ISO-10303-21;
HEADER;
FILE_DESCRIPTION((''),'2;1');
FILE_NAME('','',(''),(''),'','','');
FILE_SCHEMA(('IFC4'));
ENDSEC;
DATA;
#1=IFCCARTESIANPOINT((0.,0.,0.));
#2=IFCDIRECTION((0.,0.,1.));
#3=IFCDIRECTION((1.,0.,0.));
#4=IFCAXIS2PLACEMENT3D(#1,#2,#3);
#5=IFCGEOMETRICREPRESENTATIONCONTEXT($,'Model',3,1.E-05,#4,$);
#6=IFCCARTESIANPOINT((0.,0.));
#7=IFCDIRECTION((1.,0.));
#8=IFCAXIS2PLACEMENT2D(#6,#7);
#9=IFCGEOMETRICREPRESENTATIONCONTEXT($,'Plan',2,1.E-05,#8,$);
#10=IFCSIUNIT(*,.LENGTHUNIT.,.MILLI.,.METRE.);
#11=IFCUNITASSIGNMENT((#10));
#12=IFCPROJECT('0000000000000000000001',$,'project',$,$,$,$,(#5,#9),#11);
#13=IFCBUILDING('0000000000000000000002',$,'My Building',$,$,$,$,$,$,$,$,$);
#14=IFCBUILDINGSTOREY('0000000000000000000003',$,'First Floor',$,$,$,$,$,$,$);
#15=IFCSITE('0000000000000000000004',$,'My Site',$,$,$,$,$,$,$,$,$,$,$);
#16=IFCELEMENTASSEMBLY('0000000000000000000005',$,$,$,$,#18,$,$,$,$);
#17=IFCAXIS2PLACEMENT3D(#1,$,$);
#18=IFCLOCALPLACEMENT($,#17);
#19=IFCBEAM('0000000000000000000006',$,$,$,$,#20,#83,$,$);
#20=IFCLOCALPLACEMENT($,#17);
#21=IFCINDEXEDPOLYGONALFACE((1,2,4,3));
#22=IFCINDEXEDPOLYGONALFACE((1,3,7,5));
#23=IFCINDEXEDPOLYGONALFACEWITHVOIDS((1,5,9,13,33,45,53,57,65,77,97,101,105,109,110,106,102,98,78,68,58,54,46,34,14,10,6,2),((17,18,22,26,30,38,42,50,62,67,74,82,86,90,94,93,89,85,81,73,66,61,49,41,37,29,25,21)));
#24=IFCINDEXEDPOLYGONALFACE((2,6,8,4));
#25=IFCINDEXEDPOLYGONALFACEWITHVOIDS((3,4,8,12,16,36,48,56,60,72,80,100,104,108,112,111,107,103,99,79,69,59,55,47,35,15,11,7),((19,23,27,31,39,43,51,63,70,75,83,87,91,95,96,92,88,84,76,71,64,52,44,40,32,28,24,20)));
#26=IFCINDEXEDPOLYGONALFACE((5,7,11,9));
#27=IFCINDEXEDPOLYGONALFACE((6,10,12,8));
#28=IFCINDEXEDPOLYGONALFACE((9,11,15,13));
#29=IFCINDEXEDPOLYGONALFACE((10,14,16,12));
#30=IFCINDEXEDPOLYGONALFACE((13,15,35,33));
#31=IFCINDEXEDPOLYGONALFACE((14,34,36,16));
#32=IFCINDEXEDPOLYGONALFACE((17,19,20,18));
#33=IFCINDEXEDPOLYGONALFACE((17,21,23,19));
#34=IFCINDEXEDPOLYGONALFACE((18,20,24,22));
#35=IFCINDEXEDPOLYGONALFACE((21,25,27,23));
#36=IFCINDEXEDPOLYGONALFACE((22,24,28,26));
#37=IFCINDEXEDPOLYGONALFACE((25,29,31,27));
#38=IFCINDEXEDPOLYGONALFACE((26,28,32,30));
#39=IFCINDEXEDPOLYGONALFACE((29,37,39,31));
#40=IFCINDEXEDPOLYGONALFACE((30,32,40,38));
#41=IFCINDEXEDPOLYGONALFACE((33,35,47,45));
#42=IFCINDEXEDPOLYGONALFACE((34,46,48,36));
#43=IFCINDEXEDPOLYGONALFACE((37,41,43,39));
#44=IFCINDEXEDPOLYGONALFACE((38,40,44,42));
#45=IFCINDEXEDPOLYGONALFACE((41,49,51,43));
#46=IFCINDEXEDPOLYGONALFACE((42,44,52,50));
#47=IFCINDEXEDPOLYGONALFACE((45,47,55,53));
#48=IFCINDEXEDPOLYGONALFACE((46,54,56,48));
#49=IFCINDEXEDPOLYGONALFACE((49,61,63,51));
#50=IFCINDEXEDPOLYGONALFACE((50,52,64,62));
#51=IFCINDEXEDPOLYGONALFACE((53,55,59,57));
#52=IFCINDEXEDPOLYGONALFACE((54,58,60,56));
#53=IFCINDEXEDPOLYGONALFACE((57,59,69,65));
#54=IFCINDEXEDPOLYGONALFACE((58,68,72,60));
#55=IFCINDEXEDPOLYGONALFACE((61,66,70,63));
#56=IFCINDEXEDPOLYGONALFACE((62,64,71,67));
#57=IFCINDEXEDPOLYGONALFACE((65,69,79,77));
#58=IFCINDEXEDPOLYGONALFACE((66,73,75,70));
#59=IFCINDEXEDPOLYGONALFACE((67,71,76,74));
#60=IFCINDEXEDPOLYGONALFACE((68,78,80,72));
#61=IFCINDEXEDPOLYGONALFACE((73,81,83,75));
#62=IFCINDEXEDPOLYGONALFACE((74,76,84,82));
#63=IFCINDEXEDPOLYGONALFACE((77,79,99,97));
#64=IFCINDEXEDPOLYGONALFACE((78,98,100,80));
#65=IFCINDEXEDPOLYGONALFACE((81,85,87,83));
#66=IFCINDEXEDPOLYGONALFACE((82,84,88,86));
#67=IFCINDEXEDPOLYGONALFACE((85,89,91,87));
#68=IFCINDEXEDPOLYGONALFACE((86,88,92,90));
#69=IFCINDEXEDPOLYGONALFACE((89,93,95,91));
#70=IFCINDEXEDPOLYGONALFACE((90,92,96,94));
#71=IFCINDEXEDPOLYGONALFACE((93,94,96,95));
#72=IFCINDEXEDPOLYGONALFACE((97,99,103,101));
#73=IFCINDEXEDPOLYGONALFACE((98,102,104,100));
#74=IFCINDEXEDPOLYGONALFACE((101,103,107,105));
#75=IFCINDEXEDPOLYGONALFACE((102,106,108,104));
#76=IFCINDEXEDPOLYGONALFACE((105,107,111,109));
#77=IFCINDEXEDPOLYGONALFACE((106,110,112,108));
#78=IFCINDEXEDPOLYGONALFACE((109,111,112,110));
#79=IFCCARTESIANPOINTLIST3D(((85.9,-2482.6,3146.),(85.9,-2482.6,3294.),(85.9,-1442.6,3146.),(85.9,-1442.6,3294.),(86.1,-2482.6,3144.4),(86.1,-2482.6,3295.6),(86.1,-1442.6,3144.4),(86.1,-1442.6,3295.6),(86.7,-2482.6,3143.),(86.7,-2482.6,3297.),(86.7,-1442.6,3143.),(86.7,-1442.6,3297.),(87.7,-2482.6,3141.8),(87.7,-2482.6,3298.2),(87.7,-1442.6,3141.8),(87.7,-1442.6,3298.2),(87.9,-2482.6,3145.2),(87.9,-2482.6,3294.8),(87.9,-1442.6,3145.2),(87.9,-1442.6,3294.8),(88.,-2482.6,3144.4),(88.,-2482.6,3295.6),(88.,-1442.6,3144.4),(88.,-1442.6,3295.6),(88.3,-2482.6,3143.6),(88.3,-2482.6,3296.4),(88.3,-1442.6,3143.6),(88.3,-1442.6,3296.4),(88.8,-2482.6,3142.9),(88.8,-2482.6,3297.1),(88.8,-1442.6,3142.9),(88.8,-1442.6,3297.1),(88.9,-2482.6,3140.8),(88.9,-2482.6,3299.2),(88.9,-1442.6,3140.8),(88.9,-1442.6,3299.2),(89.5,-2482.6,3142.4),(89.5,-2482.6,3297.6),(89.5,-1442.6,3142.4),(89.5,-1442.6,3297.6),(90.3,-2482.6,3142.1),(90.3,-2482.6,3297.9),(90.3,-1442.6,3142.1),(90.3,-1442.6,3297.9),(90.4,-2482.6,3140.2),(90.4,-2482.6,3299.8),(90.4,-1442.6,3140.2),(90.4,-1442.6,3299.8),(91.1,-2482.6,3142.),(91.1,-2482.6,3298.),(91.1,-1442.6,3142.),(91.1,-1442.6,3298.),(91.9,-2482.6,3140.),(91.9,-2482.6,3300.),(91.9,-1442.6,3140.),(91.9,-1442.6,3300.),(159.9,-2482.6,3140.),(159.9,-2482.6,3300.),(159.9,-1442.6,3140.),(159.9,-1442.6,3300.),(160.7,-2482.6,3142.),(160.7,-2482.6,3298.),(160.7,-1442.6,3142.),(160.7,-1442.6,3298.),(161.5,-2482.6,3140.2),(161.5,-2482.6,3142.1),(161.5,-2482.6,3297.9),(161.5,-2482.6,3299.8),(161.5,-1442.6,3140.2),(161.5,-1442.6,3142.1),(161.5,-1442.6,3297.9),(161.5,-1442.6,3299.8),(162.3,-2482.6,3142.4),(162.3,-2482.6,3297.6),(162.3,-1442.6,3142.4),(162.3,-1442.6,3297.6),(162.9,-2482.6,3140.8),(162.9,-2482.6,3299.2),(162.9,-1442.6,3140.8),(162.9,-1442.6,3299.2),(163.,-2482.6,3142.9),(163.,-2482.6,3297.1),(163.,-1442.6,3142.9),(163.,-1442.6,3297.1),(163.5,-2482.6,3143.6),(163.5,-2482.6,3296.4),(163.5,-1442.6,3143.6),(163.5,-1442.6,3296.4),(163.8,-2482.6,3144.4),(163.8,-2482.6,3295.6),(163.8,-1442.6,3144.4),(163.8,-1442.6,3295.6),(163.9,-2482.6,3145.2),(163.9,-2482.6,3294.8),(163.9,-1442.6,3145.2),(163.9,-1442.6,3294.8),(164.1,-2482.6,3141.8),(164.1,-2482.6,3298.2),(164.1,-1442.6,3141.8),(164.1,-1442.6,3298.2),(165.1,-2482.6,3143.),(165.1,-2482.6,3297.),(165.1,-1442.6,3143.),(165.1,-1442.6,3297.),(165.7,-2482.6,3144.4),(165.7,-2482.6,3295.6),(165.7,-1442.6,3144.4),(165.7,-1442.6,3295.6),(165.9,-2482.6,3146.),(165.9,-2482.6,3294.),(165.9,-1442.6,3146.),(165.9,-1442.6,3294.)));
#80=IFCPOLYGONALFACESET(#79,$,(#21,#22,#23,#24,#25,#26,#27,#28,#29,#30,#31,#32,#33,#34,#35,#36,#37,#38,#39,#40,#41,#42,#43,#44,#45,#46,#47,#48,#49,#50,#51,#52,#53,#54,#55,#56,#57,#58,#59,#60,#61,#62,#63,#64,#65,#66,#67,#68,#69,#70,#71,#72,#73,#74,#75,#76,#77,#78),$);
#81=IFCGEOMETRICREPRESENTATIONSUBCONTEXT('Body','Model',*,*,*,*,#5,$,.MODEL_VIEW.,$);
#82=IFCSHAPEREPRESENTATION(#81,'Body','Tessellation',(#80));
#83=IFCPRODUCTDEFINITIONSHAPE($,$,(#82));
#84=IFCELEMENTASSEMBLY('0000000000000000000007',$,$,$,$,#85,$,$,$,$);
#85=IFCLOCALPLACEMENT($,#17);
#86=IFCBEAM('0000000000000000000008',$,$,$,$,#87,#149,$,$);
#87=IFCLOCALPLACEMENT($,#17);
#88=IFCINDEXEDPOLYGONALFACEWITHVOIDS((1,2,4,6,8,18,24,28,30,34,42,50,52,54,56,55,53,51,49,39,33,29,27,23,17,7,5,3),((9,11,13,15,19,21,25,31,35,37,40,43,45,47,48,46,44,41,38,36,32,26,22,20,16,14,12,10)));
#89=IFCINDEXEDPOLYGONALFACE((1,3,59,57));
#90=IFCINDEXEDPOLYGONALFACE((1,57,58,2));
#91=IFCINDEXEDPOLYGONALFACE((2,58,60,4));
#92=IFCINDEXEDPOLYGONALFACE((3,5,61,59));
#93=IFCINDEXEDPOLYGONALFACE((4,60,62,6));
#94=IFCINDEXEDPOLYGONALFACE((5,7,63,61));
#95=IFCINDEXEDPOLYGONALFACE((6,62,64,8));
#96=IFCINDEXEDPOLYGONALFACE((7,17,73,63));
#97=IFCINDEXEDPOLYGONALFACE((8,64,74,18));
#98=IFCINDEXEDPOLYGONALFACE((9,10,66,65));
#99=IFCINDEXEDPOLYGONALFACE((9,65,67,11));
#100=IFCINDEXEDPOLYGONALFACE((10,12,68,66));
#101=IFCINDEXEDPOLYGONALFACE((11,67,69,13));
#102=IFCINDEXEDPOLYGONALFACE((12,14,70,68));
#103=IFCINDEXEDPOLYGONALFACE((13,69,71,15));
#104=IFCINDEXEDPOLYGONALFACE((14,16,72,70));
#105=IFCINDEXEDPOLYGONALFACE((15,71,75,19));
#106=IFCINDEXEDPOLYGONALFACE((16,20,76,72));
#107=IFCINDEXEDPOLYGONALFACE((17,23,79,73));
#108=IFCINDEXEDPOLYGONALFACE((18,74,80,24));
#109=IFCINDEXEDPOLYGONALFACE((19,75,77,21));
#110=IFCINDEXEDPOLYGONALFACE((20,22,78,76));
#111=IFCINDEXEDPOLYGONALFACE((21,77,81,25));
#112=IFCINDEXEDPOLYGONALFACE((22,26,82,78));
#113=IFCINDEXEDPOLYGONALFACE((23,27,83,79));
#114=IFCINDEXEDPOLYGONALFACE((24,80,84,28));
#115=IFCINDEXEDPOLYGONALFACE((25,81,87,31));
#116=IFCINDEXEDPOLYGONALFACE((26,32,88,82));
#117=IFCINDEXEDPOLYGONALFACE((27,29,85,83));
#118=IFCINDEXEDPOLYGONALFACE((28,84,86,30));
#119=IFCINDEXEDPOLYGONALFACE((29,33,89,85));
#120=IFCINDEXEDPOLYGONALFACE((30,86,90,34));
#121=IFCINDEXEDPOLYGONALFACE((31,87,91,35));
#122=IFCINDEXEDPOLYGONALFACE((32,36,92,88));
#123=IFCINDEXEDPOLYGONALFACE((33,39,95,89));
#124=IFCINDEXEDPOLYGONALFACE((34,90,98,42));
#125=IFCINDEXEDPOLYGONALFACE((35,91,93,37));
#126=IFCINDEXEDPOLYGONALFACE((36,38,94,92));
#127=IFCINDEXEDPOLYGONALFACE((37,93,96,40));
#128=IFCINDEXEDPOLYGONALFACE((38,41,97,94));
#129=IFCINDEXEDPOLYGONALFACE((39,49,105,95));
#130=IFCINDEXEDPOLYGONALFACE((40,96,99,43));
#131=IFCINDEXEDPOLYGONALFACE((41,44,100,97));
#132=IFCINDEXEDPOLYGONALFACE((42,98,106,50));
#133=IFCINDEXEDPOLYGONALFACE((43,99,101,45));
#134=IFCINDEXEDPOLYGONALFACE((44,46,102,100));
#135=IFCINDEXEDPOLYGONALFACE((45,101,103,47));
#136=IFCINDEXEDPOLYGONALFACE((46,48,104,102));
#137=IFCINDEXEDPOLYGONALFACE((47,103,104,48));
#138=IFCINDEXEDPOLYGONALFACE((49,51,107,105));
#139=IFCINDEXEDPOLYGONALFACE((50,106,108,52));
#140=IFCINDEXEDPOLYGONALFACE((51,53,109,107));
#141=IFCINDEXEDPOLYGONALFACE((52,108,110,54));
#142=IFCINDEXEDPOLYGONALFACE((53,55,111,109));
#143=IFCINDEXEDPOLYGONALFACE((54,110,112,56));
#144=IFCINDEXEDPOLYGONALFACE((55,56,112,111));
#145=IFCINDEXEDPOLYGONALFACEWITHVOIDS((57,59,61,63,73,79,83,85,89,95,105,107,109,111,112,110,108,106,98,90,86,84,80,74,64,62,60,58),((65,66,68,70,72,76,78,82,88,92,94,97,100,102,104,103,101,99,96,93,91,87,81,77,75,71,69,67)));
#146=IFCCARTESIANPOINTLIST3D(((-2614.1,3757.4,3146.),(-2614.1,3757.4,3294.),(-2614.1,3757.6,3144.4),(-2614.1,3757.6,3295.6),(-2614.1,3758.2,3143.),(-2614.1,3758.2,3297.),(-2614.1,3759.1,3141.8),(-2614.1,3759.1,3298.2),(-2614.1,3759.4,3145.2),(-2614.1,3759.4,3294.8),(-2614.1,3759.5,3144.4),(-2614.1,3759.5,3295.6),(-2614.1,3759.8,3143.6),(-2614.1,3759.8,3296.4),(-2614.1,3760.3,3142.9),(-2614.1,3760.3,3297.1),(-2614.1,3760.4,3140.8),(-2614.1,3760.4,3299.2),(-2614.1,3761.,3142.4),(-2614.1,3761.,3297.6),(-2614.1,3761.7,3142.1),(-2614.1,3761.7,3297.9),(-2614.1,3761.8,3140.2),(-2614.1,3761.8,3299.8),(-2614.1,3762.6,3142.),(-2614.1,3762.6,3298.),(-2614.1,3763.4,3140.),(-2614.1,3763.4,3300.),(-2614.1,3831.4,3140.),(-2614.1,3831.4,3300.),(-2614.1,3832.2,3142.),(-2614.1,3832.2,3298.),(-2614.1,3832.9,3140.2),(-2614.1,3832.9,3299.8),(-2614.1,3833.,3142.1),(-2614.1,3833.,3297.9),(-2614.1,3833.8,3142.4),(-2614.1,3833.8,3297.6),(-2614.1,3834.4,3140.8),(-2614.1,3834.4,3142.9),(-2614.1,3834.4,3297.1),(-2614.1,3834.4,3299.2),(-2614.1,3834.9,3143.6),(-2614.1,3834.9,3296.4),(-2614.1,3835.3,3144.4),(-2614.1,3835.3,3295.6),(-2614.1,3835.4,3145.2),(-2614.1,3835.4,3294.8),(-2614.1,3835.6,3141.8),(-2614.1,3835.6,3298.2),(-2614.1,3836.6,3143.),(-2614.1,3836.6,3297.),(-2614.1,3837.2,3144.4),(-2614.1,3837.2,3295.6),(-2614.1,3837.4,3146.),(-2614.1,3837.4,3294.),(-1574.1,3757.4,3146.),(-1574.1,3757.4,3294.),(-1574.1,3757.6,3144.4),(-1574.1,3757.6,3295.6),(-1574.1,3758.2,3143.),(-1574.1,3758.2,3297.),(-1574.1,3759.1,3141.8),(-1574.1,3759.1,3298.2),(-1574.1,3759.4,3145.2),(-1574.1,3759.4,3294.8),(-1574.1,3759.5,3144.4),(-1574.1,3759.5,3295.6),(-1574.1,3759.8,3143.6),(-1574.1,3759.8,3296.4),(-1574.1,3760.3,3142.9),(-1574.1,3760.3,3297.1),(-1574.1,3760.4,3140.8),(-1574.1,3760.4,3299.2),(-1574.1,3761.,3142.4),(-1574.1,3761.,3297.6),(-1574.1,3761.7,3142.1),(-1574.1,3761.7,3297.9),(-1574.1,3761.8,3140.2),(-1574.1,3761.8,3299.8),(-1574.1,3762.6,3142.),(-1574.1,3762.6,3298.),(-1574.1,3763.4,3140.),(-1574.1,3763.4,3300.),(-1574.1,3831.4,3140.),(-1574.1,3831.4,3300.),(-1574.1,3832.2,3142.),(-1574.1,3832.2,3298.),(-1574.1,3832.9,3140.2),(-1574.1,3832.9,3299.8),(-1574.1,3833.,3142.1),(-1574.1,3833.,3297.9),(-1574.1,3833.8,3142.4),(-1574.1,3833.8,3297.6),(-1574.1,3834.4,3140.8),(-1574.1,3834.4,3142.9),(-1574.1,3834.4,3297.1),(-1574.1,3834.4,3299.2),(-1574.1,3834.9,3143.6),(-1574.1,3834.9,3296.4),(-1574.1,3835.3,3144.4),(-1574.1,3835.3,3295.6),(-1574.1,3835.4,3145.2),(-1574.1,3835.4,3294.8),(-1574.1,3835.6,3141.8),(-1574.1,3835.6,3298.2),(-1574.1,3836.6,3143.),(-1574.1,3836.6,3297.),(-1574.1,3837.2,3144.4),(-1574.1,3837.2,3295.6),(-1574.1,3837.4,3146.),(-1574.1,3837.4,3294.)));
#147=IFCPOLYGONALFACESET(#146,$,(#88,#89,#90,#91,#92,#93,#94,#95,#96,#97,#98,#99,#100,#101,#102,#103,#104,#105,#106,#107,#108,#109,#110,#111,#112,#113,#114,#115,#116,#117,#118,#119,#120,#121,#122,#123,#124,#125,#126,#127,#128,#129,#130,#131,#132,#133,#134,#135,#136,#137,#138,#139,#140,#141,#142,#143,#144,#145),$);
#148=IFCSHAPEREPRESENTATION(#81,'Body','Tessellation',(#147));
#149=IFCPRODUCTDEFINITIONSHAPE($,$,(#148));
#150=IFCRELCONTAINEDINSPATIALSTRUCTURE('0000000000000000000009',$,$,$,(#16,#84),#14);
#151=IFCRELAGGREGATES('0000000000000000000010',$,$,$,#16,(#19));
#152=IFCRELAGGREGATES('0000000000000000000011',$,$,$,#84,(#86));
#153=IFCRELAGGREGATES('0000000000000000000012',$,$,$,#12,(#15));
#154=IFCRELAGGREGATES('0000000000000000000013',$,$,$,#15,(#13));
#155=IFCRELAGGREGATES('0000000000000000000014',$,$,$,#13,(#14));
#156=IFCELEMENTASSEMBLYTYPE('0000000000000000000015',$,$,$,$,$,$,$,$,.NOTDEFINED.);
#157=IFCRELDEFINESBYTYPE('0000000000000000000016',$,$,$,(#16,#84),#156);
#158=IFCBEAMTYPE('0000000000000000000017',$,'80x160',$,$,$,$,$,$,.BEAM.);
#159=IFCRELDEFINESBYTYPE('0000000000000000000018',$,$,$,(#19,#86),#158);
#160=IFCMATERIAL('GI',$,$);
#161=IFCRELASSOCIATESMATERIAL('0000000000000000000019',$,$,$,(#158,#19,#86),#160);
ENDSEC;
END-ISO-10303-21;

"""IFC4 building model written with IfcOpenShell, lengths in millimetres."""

from ifc_helpers import new_model, si_unit, frame, origin_with_axes, origin_2d_with_axis, place, context, subcontext, project, spatial, hollow_rectangle, extrude, material, material_profile, profile_set, profile_usage, type_object, element, aggregate, save


model = new_model("IFC4")

# Units and contexts
model_context = context("Model", 3, precision=1e-05, world=origin_with_axes())
plan_context = context("Plan", 2, precision=1e-05, world=origin_2d_with_axis())
body_context = subcontext(model_context, "Body", "Model", "MODEL_VIEW")
ifc_project = project(units=[si_unit("LENGTHUNIT", "METRE", prefix="MILLI")], contexts=[model_context, plan_context])

# Site, building, storey
site = spatial("IfcSite", under=ifc_project, Name="My Site")
building = spatial("IfcBuilding", under=site, Name="My Building")
storey = spatial("IfcBuildingStorey", under=building, Name="First Floor")

# Element assemblies, beams
element_assembly_type = type_object("IfcElementAssemblyType", PredefinedType="NOTDEFINED")
ifc_material = material(Name="GI")
ifc_material_profile = material_profile(ifc_material, hollow_rectangle(XDim=80.0, YDim=160.0, WallThickness=2.0, InnerFilletRadius=3.2, OuterFilletRadius=6.0))
ifc_profile_set = profile_set([ifc_material_profile], Name="80x160 GI Rectangular Hollow")
beam_type = type_object("IfcBeamType", Name="80x160", PredefinedType="BEAM", material=ifc_profile_set)
assembly_1_placement = place(None, frame((125.9, -2562.6, 3220.0), z_axis=(0.0, 1.0, 0.0), x_axis=(1.0, 0.0, 0.0)))
assembly_1 = element("IfcElementAssembly", 1, at=assembly_1_placement, inside=storey, type_object=element_assembly_type)
ifc_profile_usage_1 = profile_usage(ifc_profile_set)
beam_1_placement = place(assembly_1_placement, frame((0.0, 0.0, 80.0), z_axis=(0.0, 0.0, 1.0), x_axis=(1.0, 0.0, 0.0)))
beam_1 = element("IfcBeam", 2, at=beam_1_placement, type_object=beam_type, material=ifc_profile_usage_1, context=body_context, shape_type="SweptSolid", body=[
    extrude(hollow_rectangle(XDim=80.0, YDim=160.0, WallThickness=2.0, InnerFilletRadius=3.2, OuterFilletRadius=6.0), origin_with_axes(), (0.0, 0.0, 1.0), 1040.0),
])
aggregate(assembly_1, [beam_1])
assembly_2_placement = place(None, frame((-2694.1, 3797.4, 3220.0), z_axis=(1.0, 0.0, 0.0), x_axis=(0.0, 1.0, 0.0)))
assembly_2 = element("IfcElementAssembly", 3, at=assembly_2_placement, inside=storey, type_object=element_assembly_type)
ifc_profile_usage_2 = profile_usage(ifc_profile_set)
beam_2_placement = place(assembly_2_placement, frame((0.0, 0.0, 80.0), z_axis=(0.0, 0.0, 1.0), x_axis=(1.0, 0.0, 0.0)))
beam_2 = element("IfcBeam", 4, at=beam_2_placement, type_object=beam_type, material=ifc_profile_usage_2, context=body_context, shape_type="SweptSolid", body=[
    extrude(hollow_rectangle(XDim=80.0, YDim=160.0, WallThickness=2.0, InnerFilletRadius=3.2, OuterFilletRadius=6.0), origin_with_axes(), (0.0, 0.0, 1.0), 1040.0),
])
aggregate(assembly_2, [beam_2])

save(model, "model.ifc")
